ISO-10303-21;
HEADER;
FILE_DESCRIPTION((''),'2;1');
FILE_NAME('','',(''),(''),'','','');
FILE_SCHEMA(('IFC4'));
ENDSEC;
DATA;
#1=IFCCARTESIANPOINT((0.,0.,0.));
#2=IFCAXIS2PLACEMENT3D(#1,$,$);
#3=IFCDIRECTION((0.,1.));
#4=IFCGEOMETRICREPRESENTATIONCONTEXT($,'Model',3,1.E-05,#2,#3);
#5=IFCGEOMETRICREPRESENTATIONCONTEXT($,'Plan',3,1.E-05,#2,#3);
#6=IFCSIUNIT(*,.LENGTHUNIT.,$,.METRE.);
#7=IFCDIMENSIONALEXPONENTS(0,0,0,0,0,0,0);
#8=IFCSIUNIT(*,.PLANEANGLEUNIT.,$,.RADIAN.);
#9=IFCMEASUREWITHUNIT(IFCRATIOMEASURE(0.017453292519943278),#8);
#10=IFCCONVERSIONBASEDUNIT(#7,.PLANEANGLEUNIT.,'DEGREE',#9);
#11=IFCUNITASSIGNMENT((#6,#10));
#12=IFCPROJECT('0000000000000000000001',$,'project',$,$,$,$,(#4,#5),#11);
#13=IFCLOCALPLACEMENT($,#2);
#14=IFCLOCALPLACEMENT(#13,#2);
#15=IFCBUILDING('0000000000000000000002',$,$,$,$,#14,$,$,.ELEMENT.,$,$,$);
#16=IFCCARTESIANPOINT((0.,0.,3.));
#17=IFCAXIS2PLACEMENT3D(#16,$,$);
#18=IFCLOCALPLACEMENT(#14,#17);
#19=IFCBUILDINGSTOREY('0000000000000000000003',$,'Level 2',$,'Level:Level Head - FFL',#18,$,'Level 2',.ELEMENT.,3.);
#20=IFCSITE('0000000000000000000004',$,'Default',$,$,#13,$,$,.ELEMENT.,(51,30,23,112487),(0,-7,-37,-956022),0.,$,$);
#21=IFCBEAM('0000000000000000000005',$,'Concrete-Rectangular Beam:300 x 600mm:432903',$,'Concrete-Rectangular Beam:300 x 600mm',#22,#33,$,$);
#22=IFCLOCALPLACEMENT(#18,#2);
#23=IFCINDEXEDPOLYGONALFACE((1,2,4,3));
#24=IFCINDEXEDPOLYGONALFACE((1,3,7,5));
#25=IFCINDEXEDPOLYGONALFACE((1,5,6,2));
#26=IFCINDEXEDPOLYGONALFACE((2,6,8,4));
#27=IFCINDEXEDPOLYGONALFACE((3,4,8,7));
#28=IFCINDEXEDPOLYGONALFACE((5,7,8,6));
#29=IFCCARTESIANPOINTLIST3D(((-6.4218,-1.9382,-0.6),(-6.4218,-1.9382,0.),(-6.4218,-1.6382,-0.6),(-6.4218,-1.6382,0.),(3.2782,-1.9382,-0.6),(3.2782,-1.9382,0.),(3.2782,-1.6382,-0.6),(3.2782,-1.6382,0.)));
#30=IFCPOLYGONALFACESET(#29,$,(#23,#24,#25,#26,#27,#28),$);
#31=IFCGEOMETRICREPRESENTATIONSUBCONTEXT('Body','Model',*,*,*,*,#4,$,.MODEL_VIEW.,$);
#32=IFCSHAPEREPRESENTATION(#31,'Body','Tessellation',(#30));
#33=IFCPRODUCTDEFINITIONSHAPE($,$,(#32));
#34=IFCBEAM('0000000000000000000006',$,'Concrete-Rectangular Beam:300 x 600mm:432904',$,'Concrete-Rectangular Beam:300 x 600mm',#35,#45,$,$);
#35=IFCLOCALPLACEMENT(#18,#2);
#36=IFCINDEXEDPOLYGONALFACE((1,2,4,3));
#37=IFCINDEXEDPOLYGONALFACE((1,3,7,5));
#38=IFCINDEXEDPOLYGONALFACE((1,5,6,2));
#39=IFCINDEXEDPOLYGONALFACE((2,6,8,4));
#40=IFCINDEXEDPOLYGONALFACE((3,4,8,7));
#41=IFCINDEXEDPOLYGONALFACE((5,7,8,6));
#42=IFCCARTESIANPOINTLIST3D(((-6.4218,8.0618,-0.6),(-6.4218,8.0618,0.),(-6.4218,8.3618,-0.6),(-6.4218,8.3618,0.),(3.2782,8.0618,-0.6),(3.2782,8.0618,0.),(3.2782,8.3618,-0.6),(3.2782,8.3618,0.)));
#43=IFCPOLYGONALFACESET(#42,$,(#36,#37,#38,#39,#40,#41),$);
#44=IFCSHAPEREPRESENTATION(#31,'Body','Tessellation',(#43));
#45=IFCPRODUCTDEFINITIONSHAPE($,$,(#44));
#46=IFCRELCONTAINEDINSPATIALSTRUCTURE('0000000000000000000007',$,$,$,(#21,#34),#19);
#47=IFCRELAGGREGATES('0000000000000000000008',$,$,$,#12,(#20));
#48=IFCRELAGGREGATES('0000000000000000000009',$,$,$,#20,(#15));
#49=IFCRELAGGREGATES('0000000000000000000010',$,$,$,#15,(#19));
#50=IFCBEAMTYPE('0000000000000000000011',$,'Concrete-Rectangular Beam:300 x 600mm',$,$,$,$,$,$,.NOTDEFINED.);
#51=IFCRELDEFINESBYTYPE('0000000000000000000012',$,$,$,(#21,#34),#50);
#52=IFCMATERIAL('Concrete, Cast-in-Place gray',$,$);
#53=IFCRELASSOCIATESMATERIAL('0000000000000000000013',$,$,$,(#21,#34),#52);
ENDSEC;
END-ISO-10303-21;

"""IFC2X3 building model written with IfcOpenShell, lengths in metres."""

from ifc_helpers import new_model, entity, si_unit, converted_unit, direction, frame, frame_2d, origin, place, context, subcontext, project, spatial, rectangle, extrude, material, type_object, element, save


model = new_model("IFC2X3")

# Units and contexts
model_context = context("Model", 3, precision=1e-05, world=origin(), true_north=direction((0.0, 1.0)))
plan_context = context("Plan", 3, precision=1e-05, world=origin(), true_north=direction((0.0, 1.0)))
body_context = subcontext(model_context, "Body", "Model", "MODEL_VIEW")
ifc_project = project(units=[si_unit("LENGTHUNIT", "METRE"), converted_unit("PLANEANGLEUNIT", "DEGREE", entity("IfcRatioMeasure", 0.017453292519943278), si_unit("PLANEANGLEUNIT", "RADIAN"), dimensions=[0, 0, 0, 0, 0, 0, 0])], contexts=[model_context, plan_context])

# Site, building, storey
site_placement = place(None, origin())
site = spatial("IfcSite", under=ifc_project, at=site_placement, Name="Default", CompositionType="ELEMENT", RefLatitude=(51, 30, 23, 112487), RefLongitude=(0, -7, -37, -956022), RefElevation=0.0)
building_placement = place(site_placement, origin())
building = spatial("IfcBuilding", under=site, at=building_placement, CompositionType="ELEMENT")
storey_placement = place(building_placement, frame((0.0, 0.0, 3.0)))
storey = spatial("IfcBuildingStorey", under=building, at=storey_placement, Name="Level 2", ObjectType="Level:Level Head - FFL", LongName="Level 2", CompositionType="ELEMENT", Elevation=3.0)

# Beams
ifc_material_1 = material(Name="Concrete, Cast-in-Place gray")
beam_type = type_object("IfcBeamType", Name="Concrete-Rectangular Beam:300 x 600mm", PredefinedType="NOTDEFINED")
beam_1_placement = place(storey_placement, frame((3.4282, -1.7882, 0.0), z_axis=(0.0, 0.0, 1.0), x_axis=(-1.0, 0.0, 0.0)))
element("IfcBeam", 1, at=beam_1_placement, inside=storey, type_object=beam_type, material=ifc_material_1, Name="Concrete-Rectangular Beam:300 x 600mm:432903", ObjectType="Concrete-Rectangular Beam:300 x 600mm", context=body_context, shape_type="SweptSolid", body=[
    extrude(rectangle(XDim=0.6, YDim=0.3, at=frame_2d((0.0, 0.0), x_axis=(1.0, 0.0))), frame((0.15, 0.0, -0.3), z_axis=(1.0, 0.0, 0.0), x_axis=(0.0, 0.0, -1.0)), (0.0, 0.0, 1.0), 9.7),
])
beam_2_placement = place(storey_placement, frame((3.4282, 8.2118, 0.0), z_axis=(0.0, 0.0, 1.0), x_axis=(-1.0, 0.0, 0.0)))
element("IfcBeam", 2, at=beam_2_placement, inside=storey, type_object=beam_type, material=ifc_material_1, Name="Concrete-Rectangular Beam:300 x 600mm:432904", ObjectType="Concrete-Rectangular Beam:300 x 600mm", context=body_context, shape_type="SweptSolid", body=[
    extrude(rectangle(XDim=0.6, YDim=0.3, at=frame_2d((0.0, 0.0), x_axis=(1.0, 0.0))), frame((0.15, 0.0, -0.3), z_axis=(1.0, 0.0, 0.0), x_axis=(0.0, 0.0, -1.0)), (0.0, 0.0, 1.0), 9.7),
])

save(model, "model.ifc")
